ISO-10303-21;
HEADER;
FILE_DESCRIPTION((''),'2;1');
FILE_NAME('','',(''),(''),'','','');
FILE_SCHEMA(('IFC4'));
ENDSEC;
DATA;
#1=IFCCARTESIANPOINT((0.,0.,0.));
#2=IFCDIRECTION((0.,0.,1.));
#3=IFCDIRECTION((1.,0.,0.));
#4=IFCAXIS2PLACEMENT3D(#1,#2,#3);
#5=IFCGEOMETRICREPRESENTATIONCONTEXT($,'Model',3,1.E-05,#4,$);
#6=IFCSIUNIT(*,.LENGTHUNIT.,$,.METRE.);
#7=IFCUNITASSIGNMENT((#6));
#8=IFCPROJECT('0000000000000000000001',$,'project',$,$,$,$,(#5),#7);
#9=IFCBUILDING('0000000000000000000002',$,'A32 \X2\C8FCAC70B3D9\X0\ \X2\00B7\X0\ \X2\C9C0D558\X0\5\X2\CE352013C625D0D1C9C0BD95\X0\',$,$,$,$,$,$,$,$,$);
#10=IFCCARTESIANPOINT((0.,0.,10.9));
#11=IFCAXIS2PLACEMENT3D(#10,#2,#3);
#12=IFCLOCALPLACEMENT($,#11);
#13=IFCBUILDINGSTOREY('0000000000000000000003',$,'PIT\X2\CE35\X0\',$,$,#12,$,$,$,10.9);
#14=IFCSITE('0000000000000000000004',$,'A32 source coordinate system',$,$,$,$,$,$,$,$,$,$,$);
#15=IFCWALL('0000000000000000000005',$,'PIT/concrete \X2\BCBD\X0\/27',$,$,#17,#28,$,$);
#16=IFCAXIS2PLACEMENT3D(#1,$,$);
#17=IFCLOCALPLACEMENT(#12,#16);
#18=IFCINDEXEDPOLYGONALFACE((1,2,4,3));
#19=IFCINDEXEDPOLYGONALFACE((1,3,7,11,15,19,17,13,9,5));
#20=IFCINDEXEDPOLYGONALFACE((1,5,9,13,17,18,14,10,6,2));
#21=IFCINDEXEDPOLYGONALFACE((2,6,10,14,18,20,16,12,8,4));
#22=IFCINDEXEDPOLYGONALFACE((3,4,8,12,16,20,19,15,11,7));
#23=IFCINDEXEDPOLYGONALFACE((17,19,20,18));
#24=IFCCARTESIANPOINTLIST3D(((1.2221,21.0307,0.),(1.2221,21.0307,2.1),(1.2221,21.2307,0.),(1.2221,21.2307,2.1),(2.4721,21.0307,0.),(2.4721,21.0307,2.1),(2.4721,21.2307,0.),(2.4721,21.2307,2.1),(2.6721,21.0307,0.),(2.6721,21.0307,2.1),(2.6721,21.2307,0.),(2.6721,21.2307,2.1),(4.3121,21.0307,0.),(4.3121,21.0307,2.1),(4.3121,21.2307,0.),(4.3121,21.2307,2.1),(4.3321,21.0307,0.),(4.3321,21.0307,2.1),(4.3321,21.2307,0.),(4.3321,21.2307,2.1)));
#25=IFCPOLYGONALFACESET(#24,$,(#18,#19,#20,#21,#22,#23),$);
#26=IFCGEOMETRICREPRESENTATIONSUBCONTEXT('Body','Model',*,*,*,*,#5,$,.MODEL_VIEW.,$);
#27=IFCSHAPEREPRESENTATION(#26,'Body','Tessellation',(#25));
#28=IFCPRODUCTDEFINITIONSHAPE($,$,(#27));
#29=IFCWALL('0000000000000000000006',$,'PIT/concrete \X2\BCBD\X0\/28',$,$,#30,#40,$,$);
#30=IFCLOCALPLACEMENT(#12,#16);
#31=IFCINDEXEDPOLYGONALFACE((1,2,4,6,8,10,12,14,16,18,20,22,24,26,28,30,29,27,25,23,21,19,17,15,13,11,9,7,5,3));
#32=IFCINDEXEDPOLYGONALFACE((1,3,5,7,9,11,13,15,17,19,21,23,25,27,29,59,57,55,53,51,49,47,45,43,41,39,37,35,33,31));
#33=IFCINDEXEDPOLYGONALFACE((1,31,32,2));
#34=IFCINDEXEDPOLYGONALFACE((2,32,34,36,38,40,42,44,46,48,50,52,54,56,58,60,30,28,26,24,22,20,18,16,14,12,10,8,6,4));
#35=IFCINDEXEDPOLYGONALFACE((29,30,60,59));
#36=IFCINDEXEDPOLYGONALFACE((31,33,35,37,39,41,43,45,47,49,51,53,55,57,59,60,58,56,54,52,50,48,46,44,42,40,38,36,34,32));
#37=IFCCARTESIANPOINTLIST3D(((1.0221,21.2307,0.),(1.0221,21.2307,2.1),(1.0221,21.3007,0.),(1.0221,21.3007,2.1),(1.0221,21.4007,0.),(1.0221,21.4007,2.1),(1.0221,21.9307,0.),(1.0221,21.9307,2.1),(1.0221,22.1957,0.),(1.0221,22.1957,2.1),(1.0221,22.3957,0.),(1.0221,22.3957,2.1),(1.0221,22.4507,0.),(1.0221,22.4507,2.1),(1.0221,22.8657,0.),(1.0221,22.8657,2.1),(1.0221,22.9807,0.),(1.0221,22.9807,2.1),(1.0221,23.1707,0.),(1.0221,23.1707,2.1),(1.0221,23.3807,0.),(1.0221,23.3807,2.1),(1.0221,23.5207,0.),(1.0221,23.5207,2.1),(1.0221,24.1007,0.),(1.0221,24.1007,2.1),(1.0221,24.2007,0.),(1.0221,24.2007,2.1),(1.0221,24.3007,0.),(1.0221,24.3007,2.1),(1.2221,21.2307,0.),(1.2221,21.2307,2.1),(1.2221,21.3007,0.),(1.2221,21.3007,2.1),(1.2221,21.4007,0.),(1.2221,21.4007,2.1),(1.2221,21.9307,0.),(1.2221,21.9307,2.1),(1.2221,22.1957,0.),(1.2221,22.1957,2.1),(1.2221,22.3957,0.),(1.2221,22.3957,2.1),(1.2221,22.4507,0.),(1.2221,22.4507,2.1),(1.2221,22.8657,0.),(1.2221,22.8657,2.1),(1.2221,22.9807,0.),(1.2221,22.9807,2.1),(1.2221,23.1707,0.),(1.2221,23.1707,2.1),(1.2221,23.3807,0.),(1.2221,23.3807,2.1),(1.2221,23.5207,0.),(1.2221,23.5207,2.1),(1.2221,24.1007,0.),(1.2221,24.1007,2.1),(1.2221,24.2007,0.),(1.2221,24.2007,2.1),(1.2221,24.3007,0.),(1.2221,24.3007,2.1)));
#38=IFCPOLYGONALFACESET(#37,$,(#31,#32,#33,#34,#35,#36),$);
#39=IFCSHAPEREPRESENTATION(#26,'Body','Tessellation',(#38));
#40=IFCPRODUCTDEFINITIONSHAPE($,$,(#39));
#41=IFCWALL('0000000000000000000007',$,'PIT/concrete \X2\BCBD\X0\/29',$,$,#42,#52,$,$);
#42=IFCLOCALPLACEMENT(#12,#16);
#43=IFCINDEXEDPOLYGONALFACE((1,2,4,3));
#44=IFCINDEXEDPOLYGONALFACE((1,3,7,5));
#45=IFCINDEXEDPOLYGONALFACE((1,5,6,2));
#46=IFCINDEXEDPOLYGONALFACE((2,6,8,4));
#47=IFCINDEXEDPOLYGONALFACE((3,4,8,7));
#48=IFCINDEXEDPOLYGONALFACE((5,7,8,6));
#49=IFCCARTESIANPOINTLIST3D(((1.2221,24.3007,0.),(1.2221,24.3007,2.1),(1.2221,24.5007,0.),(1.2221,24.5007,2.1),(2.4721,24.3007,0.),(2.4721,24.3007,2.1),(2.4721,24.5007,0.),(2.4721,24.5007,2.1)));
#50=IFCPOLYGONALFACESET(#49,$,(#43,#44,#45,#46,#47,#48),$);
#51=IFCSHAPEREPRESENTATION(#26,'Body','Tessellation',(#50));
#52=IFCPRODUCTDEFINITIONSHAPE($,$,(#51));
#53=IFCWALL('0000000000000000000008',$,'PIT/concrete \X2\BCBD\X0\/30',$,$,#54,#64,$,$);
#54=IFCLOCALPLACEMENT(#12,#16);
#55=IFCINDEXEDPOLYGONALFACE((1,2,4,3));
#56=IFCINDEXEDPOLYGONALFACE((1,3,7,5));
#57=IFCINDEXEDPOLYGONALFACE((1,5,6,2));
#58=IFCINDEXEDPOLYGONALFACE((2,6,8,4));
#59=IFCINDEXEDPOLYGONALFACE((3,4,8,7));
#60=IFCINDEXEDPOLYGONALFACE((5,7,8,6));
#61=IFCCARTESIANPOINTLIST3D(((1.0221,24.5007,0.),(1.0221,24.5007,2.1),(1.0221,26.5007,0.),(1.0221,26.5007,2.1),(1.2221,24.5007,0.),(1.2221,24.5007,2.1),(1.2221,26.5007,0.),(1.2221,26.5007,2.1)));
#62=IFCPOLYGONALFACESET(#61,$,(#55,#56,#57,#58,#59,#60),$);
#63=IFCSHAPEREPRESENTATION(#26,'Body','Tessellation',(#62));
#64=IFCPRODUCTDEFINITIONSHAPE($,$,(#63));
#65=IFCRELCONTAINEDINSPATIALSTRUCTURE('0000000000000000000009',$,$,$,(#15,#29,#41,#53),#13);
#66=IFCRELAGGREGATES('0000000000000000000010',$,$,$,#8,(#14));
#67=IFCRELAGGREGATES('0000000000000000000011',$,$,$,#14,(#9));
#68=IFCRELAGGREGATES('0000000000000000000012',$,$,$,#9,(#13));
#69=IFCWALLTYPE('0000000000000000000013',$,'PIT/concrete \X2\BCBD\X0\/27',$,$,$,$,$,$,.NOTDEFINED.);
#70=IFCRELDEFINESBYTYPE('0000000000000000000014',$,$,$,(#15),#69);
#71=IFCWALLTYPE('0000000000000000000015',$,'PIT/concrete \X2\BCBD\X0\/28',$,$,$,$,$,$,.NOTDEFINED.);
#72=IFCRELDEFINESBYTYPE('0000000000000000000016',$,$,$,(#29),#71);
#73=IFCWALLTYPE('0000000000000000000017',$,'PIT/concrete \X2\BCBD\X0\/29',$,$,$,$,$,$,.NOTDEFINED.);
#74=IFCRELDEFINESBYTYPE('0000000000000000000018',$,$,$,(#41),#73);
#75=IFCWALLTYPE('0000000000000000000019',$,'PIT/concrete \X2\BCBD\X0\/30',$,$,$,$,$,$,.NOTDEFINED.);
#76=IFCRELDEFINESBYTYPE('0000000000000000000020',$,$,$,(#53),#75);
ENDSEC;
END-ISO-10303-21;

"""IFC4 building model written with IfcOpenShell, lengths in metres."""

from ifc_helpers import new_model, si_unit, frame, origin, origin_with_axes, place, context, subcontext, project, spatial, polyline, outline, extrude, source, transform, mapped, type_object, type_shapes, element, save


model = new_model("IFC4")

# Units and contexts
model_context = context("Model", 3, precision=1e-05, world=origin_with_axes())
body_context = subcontext(model_context, "Body", "Model", "MODEL_VIEW")
ifc_project = project(units=[si_unit("LENGTHUNIT", "METRE")], contexts=[model_context])

# Site, building, storey
site = spatial("IfcSite", under=ifc_project, Name="A32 source coordinate system")
building = spatial("IfcBuilding", under=site, Name="A32 주거동 · 지하5층–옥탑지붕")
storey_placement = place(None, frame((0.0, 0.0, 10.9), z_axis=(0.0, 0.0, 1.0), x_axis=(1.0, 0.0, 0.0)))
storey = spatial("IfcBuildingStorey", under=building, at=storey_placement, Name="PIT층", Elevation=10.9)

# Walls
wall_type_1 = type_object("IfcWallType", Name="PIT/concrete 벽/27", PredefinedType="NOTDEFINED")
shared_shape_1 = source(origin(), body_context, "Body", "SweptSolid", [
    extrude(outline(polyline([(2.6721, 21.2307), (4.3121, 21.2307), (4.3321, 21.2307), (4.3321, 21.0307), (4.3121, 21.0307), (2.6721, 21.0307), (2.4721, 21.0307), (1.2221, 21.0307), (1.2221, 21.2307), (2.4721, 21.2307), (2.6721, 21.2307)])), origin(), (0.0, 0.0, 1.0), 2.1),
])
type_shapes(wall_type_1, [shared_shape_1])
wall_1_placement = place(storey_placement, origin_with_axes())
element("IfcWall", 1, at=wall_1_placement, inside=storey, type_object=wall_type_1, Name="PIT/concrete 벽/27", context=body_context, shape_type="MappedRepresentation", body=[
    mapped(shared_shape_1, transform((0.0, 0.0, 0.0), scale=1.0)),
])
wall_type_2 = type_object("IfcWallType", Name="PIT/concrete 벽/28", PredefinedType="NOTDEFINED")
shared_shape_2 = source(origin(), body_context, "Body", "SweptSolid", [
    extrude(outline(polyline([(1.0221, 21.4007), (1.0221, 21.9307), (1.0221, 22.1957), (1.0221, 22.3957), (1.0221, 22.4507), (1.0221, 22.8657), (1.0221, 22.9807), (1.0221, 23.1707), (1.0221, 23.3807), (1.0221, 23.5207), (1.0221, 24.1007), (1.0221, 24.2007), (1.0221, 24.3007), (1.2221, 24.3007), (1.2221, 24.2007), (1.2221, 24.1007), (1.2221, 23.5207), (1.2221, 23.3807), (1.2221, 23.1707), (1.2221, 22.9807), (1.2221, 22.8657), (1.2221, 22.4507), (1.2221, 22.3957), (1.2221, 22.1957), (1.2221, 21.9307), (1.2221, 21.4007), (1.2221, 21.3007), (1.2221, 21.2307), (1.0221, 21.2307), (1.0221, 21.3007), (1.0221, 21.4007)])), origin(), (0.0, 0.0, 1.0), 2.1),
])
type_shapes(wall_type_2, [shared_shape_2])
wall_2_placement = place(storey_placement, origin_with_axes())
element("IfcWall", 2, at=wall_2_placement, inside=storey, type_object=wall_type_2, Name="PIT/concrete 벽/28", context=body_context, shape_type="MappedRepresentation", body=[
    mapped(shared_shape_2, transform((0.0, 0.0, 0.0), scale=1.0)),
])
wall_type_3 = type_object("IfcWallType", Name="PIT/concrete 벽/29", PredefinedType="NOTDEFINED")
shared_shape_3 = source(origin(), body_context, "Body", "SweptSolid", [
    extrude(outline(polyline([(2.4721, 24.3007), (1.2221, 24.3007), (1.2221, 24.5007), (2.4721, 24.5007), (2.4721, 24.3007)])), origin(), (0.0, 0.0, 1.0), 2.1),
])
type_shapes(wall_type_3, [shared_shape_3])
wall_3_placement = place(storey_placement, origin_with_axes())
element("IfcWall", 3, at=wall_3_placement, inside=storey, type_object=wall_type_3, Name="PIT/concrete 벽/29", context=body_context, shape_type="MappedRepresentation", body=[
    mapped(shared_shape_3, transform((0.0, 0.0, 0.0), scale=1.0)),
])
wall_type_4 = type_object("IfcWallType", Name="PIT/concrete 벽/30", PredefinedType="NOTDEFINED")
shared_shape_4 = source(origin(), body_context, "Body", "SweptSolid", [
    extrude(outline(polyline([(1.2221, 26.5007), (1.2221, 24.5007), (1.0221, 24.5007), (1.0221, 26.5007), (1.2221, 26.5007)])), origin(), (0.0, 0.0, 1.0), 2.1),
])
type_shapes(wall_type_4, [shared_shape_4])
wall_4_placement = place(storey_placement, origin_with_axes())
element("IfcWall", 4, at=wall_4_placement, inside=storey, type_object=wall_type_4, Name="PIT/concrete 벽/30", context=body_context, shape_type="MappedRepresentation", body=[
    mapped(shared_shape_4, transform((0.0, 0.0, 0.0), scale=1.0)),
])

save(model, "model.ifc")
